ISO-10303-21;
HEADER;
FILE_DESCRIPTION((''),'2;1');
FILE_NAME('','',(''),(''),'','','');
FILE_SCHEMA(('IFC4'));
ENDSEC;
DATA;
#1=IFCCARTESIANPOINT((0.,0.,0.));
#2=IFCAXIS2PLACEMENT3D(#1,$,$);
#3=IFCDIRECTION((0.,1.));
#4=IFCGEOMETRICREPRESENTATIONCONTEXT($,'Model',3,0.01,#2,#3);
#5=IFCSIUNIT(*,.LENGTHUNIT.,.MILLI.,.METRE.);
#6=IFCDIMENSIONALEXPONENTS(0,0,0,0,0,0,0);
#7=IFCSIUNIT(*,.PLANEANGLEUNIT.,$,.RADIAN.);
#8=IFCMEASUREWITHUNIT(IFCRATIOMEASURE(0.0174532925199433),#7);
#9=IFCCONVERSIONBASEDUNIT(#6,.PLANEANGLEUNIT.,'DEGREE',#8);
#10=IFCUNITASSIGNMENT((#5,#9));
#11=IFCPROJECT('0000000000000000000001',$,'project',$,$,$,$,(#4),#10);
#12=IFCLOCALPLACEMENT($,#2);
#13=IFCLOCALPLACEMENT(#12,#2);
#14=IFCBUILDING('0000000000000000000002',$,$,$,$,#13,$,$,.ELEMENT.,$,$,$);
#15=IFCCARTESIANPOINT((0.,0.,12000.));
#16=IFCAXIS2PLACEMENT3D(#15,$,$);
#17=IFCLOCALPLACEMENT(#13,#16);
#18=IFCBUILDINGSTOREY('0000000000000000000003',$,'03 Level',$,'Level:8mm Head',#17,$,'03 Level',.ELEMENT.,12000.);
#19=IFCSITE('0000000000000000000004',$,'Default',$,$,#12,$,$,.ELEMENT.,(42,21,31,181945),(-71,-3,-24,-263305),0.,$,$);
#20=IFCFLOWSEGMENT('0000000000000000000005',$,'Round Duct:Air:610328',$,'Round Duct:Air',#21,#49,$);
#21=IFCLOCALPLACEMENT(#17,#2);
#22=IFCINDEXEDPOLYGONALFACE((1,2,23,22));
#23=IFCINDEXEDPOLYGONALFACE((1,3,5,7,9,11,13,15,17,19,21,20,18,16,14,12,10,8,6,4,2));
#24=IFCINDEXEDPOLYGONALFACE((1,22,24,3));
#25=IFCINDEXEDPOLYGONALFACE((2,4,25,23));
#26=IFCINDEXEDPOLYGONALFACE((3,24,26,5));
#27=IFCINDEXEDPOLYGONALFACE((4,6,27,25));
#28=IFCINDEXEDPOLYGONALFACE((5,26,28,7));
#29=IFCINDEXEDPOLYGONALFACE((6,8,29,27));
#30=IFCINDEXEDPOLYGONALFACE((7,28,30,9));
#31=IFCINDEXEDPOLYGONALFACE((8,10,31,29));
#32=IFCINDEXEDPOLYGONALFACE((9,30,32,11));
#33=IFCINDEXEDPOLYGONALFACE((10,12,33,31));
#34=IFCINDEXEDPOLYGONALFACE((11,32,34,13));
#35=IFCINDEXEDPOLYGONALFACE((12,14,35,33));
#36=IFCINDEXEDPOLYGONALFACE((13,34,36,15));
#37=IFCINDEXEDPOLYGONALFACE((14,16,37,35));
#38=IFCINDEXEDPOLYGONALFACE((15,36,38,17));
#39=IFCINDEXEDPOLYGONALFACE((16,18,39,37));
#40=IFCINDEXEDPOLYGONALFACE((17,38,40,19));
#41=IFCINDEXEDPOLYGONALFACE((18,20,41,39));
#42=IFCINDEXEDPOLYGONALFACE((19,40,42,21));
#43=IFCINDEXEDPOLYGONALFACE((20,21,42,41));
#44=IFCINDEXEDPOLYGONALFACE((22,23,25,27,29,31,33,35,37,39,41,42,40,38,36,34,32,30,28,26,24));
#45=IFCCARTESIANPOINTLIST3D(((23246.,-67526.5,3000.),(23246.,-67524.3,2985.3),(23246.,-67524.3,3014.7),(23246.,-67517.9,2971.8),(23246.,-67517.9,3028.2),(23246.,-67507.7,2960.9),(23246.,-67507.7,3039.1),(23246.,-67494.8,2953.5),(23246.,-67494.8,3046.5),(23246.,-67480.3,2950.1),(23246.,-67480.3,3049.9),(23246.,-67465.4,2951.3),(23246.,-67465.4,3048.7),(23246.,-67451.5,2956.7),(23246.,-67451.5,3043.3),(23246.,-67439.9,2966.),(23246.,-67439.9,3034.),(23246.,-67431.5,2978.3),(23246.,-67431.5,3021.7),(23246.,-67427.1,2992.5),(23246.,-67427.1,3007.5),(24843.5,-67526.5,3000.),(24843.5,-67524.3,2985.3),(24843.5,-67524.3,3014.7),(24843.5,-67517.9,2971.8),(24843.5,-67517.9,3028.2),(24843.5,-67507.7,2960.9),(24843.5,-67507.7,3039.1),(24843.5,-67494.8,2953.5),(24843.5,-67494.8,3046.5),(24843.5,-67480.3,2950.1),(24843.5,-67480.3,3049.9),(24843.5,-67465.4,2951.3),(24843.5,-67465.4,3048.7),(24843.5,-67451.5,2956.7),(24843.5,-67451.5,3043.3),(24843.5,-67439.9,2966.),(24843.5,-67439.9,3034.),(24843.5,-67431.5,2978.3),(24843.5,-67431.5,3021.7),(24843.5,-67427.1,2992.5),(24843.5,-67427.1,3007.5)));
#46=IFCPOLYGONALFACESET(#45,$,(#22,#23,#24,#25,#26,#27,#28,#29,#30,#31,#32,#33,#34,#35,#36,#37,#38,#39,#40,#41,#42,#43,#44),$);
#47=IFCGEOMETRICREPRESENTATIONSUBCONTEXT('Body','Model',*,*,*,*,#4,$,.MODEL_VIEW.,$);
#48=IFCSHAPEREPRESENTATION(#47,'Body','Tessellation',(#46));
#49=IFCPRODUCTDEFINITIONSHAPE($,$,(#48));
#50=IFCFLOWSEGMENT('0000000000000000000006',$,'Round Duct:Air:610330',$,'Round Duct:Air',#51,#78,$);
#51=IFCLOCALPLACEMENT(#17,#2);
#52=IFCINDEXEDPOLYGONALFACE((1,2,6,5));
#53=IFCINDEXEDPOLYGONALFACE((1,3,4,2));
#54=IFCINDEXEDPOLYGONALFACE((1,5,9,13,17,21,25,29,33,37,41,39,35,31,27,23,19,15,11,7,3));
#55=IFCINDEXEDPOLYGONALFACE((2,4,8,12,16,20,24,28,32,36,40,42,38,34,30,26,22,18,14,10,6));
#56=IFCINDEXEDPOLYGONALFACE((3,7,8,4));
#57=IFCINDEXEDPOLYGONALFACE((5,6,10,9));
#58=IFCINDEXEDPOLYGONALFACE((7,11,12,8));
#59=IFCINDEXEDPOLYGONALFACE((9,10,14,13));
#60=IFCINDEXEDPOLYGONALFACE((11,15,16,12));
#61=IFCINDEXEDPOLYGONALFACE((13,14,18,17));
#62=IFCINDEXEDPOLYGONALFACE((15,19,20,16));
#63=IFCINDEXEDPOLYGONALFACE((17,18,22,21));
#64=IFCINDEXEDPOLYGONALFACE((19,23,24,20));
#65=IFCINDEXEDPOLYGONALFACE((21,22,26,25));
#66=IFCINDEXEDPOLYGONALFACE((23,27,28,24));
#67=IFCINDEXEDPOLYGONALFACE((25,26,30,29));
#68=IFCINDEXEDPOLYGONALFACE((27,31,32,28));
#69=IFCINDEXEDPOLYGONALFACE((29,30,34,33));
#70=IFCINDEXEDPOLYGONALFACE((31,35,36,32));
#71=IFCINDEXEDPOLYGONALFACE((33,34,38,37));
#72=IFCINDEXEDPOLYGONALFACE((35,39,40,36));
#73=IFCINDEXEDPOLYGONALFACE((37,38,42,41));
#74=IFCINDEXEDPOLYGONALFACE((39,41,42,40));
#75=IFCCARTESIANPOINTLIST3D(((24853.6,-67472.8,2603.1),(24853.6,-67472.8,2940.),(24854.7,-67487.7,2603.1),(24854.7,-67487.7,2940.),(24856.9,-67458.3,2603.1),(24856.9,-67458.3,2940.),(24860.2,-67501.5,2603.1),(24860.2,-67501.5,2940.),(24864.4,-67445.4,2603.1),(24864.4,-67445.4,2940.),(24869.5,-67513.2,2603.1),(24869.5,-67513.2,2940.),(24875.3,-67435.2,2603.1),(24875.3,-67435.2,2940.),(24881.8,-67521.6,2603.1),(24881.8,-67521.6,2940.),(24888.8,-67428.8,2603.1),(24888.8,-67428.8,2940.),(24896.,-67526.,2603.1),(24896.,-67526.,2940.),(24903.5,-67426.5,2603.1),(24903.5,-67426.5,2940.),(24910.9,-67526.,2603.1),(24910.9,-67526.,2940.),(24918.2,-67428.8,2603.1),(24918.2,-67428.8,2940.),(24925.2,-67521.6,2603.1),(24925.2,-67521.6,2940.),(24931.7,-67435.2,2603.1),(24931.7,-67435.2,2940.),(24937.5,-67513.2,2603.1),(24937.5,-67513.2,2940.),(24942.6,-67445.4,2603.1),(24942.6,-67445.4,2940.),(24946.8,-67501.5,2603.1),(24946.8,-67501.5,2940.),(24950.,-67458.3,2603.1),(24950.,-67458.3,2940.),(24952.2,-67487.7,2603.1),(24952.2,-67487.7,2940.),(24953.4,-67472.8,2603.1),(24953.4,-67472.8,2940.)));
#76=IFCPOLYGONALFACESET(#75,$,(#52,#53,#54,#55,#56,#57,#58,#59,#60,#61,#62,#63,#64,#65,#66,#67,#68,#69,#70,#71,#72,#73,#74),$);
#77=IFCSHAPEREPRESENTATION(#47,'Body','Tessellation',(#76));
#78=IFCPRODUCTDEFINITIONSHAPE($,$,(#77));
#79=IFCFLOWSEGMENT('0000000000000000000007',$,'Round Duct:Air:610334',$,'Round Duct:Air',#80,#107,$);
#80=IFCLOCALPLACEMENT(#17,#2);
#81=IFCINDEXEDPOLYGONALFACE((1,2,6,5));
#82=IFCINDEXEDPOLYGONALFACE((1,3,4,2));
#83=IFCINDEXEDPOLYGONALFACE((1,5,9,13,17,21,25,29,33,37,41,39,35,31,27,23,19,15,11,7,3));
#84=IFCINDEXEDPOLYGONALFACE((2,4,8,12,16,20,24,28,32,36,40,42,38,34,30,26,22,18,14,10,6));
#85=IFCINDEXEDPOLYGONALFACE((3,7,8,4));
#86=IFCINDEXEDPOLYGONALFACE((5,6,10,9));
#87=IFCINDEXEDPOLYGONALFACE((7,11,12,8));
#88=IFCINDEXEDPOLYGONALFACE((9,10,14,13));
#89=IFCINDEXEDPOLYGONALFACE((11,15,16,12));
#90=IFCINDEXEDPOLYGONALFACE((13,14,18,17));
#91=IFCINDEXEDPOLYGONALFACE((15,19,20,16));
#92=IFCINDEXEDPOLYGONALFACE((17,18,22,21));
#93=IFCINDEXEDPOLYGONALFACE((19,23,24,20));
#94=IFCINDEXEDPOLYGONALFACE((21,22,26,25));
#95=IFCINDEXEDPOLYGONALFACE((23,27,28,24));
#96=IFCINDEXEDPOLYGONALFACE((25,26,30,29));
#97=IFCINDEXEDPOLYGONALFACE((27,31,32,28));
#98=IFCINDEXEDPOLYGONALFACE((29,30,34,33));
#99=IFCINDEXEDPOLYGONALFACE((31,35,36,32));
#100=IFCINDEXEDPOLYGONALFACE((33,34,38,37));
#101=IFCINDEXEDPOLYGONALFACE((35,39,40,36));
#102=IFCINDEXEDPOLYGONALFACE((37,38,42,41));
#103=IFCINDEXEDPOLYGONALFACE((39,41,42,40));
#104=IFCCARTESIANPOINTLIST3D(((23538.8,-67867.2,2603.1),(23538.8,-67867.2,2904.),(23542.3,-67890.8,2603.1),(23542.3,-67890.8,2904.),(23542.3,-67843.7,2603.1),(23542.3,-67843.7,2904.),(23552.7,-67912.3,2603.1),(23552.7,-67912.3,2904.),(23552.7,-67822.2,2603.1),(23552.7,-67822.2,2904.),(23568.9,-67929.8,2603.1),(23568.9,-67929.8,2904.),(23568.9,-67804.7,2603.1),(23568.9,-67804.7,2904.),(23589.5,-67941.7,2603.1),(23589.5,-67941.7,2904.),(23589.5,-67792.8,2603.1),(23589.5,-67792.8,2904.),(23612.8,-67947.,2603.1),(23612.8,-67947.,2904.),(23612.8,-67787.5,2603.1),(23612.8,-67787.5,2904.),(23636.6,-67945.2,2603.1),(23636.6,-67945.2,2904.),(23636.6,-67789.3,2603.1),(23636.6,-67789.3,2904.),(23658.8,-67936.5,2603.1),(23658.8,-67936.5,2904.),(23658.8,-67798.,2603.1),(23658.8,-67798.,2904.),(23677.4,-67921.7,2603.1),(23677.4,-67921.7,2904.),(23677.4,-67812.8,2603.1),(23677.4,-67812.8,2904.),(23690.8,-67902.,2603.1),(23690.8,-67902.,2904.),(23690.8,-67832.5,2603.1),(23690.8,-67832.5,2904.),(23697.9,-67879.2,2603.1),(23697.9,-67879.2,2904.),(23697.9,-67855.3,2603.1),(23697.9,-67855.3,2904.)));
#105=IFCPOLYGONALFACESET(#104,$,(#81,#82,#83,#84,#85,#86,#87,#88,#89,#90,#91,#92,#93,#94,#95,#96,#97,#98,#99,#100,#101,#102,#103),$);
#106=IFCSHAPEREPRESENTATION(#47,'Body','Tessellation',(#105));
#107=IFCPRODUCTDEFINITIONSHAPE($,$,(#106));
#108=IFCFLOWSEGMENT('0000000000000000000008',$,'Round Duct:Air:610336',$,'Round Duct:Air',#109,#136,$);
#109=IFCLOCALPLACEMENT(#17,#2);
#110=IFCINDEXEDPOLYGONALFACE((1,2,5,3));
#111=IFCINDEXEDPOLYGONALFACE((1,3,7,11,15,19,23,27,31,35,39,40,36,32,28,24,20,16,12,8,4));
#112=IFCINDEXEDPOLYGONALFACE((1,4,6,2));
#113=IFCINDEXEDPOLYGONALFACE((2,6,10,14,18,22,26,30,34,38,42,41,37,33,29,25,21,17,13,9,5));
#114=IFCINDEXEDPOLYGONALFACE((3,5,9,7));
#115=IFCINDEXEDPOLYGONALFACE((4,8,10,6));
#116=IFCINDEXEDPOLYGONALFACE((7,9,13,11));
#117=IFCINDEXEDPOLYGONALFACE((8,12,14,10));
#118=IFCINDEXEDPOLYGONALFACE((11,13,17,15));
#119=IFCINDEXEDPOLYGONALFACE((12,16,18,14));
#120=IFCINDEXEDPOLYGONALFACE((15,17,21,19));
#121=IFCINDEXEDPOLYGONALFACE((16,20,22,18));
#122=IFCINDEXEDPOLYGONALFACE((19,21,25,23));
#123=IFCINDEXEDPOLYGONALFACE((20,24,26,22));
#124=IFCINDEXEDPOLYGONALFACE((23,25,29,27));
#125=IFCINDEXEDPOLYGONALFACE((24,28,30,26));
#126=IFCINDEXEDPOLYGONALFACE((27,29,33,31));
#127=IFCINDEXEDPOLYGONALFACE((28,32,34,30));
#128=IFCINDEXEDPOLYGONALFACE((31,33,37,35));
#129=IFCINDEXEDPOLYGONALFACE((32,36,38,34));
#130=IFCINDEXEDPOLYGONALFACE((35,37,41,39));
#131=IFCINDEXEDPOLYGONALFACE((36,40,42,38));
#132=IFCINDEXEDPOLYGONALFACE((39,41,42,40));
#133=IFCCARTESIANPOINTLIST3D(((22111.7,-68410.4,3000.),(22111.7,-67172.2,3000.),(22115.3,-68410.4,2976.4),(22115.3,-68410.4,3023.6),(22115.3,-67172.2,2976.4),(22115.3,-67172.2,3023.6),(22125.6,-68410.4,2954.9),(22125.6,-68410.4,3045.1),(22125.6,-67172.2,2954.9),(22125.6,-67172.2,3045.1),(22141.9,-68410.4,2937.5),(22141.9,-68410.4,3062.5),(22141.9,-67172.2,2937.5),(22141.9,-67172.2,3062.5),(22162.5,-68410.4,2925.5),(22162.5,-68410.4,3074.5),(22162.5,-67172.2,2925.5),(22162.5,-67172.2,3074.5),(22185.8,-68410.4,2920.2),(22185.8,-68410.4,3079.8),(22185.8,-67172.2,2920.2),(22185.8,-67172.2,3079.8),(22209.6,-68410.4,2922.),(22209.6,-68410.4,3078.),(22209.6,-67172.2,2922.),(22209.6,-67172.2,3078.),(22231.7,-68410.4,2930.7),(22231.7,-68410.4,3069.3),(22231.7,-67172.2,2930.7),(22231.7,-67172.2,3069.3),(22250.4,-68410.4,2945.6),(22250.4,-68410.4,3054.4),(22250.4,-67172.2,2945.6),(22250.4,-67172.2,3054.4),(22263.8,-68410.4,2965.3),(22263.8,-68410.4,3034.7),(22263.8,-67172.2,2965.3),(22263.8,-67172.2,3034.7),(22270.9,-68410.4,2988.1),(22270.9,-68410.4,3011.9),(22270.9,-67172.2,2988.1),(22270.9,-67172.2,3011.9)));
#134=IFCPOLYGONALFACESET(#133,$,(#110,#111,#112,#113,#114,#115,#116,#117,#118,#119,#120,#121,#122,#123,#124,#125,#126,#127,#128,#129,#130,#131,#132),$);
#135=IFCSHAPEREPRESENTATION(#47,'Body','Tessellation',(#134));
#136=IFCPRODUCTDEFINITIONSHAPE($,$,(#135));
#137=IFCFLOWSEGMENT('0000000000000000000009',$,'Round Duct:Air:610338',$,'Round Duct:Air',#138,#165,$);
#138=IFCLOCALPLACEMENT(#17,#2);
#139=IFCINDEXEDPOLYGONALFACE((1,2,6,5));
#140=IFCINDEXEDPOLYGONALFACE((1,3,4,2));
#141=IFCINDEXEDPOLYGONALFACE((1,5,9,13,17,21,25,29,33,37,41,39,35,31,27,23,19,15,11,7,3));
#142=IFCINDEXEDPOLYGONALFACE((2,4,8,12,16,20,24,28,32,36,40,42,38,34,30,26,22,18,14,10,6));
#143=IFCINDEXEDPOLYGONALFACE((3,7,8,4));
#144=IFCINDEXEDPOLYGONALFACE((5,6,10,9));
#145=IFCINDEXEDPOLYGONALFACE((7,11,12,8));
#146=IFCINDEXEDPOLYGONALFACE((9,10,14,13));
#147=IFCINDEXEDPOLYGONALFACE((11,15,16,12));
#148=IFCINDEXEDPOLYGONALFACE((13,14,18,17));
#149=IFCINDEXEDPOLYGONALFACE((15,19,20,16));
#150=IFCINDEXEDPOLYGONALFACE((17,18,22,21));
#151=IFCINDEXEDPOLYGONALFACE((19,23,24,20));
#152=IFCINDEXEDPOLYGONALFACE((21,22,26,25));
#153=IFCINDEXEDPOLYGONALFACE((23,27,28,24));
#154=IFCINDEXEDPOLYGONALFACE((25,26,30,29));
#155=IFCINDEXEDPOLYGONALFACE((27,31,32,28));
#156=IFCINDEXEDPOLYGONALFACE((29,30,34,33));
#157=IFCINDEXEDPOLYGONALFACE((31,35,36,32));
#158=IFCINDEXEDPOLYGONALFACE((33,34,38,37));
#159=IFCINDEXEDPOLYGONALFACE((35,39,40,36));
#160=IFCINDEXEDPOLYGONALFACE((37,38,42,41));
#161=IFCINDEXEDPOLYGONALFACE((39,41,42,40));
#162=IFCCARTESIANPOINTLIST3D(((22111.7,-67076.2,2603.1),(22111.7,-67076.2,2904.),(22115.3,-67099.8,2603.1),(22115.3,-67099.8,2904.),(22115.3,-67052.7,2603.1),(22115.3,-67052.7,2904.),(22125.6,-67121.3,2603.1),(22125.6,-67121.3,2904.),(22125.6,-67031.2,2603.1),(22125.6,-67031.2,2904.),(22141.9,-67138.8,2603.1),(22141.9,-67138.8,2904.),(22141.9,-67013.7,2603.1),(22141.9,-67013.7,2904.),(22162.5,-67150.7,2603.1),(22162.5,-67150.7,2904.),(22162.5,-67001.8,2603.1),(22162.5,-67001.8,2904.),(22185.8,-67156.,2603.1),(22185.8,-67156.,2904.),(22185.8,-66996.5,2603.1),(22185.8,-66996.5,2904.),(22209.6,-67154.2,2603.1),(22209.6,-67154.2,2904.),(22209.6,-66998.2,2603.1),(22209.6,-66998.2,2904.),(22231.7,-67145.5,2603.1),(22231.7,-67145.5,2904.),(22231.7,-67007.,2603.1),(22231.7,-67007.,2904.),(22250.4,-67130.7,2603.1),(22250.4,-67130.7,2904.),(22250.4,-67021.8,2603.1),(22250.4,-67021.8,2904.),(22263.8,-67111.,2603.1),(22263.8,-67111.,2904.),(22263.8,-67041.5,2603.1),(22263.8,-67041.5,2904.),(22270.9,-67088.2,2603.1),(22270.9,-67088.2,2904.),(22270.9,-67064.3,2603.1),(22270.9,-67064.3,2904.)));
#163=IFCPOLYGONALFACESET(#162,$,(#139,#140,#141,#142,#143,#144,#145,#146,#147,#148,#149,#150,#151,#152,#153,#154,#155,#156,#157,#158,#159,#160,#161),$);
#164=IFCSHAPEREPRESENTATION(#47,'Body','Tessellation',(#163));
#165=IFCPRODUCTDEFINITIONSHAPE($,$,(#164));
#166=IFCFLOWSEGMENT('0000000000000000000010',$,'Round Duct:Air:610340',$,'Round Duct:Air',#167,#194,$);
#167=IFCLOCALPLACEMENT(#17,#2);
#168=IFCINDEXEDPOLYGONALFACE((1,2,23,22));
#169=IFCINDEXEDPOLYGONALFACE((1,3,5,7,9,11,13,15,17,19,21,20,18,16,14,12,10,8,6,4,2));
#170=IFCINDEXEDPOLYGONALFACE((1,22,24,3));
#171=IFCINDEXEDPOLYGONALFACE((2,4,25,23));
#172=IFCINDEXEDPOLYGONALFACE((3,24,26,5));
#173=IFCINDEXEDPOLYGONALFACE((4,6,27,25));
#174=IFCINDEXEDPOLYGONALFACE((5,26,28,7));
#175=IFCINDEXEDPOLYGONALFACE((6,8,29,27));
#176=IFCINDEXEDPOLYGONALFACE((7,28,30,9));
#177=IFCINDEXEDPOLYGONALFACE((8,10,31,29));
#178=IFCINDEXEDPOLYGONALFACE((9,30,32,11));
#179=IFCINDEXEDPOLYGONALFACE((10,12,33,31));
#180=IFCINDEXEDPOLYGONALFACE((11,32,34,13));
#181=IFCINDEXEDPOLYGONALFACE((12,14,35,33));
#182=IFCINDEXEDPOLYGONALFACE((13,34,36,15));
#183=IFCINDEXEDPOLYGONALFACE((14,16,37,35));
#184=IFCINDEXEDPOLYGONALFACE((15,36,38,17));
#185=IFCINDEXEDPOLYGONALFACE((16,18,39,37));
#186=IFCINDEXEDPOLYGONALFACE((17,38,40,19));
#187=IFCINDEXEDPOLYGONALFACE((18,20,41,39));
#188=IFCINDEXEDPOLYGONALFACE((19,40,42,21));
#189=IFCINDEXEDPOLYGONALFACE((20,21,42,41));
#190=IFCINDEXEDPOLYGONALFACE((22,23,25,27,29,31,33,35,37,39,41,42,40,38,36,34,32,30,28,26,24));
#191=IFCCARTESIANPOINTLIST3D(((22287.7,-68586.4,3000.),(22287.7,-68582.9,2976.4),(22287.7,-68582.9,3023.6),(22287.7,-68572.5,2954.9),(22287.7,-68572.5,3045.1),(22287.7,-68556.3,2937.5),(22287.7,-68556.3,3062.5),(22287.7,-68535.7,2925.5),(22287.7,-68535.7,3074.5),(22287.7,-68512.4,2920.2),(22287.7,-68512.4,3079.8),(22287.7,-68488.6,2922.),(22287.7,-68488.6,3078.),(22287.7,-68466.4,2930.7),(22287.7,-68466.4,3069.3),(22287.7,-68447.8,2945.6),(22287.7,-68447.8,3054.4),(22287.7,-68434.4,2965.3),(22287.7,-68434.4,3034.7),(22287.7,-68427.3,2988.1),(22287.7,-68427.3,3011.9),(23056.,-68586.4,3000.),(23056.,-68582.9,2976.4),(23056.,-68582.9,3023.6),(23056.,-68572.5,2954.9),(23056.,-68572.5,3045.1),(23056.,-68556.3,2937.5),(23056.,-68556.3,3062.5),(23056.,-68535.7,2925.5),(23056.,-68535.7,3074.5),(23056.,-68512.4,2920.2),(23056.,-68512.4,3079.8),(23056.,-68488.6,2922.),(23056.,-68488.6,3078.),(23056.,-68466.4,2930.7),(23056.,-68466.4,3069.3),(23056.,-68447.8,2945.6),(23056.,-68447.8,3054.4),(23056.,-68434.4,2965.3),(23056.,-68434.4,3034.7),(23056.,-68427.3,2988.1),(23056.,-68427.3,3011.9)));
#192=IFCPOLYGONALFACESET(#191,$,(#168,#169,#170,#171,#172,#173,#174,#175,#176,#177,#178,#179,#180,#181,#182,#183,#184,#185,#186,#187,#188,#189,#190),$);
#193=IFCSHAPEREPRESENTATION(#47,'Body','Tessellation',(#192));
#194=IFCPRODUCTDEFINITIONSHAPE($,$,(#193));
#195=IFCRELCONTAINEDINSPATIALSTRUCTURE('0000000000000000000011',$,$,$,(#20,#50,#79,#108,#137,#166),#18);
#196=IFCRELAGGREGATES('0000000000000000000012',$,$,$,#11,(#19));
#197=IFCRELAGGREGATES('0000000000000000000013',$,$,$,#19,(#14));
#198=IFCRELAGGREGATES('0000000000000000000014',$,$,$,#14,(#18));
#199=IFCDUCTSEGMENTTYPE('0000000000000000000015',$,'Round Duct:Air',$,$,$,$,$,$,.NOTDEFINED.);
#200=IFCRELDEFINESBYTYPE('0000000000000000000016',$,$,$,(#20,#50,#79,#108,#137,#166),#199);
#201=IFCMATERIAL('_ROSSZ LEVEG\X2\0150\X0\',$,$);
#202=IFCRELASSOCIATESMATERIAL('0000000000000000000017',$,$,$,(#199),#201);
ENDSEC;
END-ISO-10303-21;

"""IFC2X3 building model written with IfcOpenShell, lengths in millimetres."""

from ifc_helpers import new_model, entity, si_unit, converted_unit, direction, frame, frame_2d, origin, origin_2d_with_axis, place, context, subcontext, project, spatial, circle, extrude, material, type_object, element, save


model = new_model("IFC2X3")

# Units and contexts
model_context = context("Model", 3, precision=0.01, world=origin(), true_north=direction((0.0, 1.0)))
body_context = subcontext(model_context, "Body", "Model", "MODEL_VIEW")
ifc_project = project(units=[si_unit("LENGTHUNIT", "METRE", prefix="MILLI"), converted_unit("PLANEANGLEUNIT", "DEGREE", entity("IfcRatioMeasure", 0.0174532925199433), si_unit("PLANEANGLEUNIT", "RADIAN"), dimensions=[0, 0, 0, 0, 0, 0, 0])], contexts=[model_context])

# Site, building, storey
site_placement = place(None, origin())
site = spatial("IfcSite", under=ifc_project, at=site_placement, Name="Default", CompositionType="ELEMENT", RefLatitude=(42, 21, 31, 181945), RefLongitude=(-71, -3, -24, -263305), RefElevation=0.0)
building_placement = place(site_placement, origin())
building = spatial("IfcBuilding", under=site, at=building_placement, CompositionType="ELEMENT")
storey_placement = place(building_placement, frame((0.0, 0.0, 12000.0)))
storey = spatial("IfcBuildingStorey", under=building, at=storey_placement, Name="03 Level", ObjectType="Level:8mm Head", LongName="03 Level", CompositionType="ELEMENT", Elevation=12000.0)

# Flow segments
ifc_material = material(Name="_ROSSZ LEVEGŐ")
duct_segment_type_1 = type_object("IfcDuctSegmentType", Name="Round Duct:Air", PredefinedType="NOTDEFINED", material=ifc_material)
flow_segment_1_placement = place(storey_placement, origin())
element("IfcFlowSegment", 1, at=flow_segment_1_placement, inside=storey, type_object=duct_segment_type_1, Name="Round Duct:Air:610328", ObjectType="Round Duct:Air", context=body_context, shape_type="SweptSolid", body=[
    extrude(circle(Radius=50.0, at=origin_2d_with_axis()), frame((23246.0, -67476.5, 3000.0), z_axis=(1.0, 0.0, 0.0), x_axis=(0.0, -1.0, 0.0)), (0.0, 0.0, 1.0), 1597.5),
])
flow_segment_2_placement = place(storey_placement, origin())
element("IfcFlowSegment", 2, at=flow_segment_2_placement, inside=storey, type_object=duct_segment_type_1, Name="Round Duct:Air:610330", ObjectType="Round Duct:Air", context=body_context, shape_type="SweptSolid", body=[
    extrude(circle(Radius=50.0, at=origin_2d_with_axis()), frame((24903.5, -67476.5, 2603.1), z_axis=(0.0, 0.0, 1.0), x_axis=(0.0, 1.0, 0.0)), (0.0, 0.0, 1.0), 336.9),
])
flow_segment_3_placement = place(storey_placement, origin())
element("IfcFlowSegment", 3, at=flow_segment_3_placement, inside=storey, type_object=duct_segment_type_1, Name="Round Duct:Air:610334", ObjectType="Round Duct:Air", context=body_context, shape_type="SweptSolid", body=[
    extrude(circle(Radius=80.0, at=origin_2d_with_axis()), frame((23618.8, -67867.2, 2603.1), z_axis=(0.0, 0.0, 1.0), x_axis=(-1.0, 0.0, 0.0)), (0.0, 0.0, 1.0), 300.9),
])
flow_segment_4_placement = place(storey_placement, origin())
element("IfcFlowSegment", 4, at=flow_segment_4_placement, inside=storey, type_object=duct_segment_type_1, Name="Round Duct:Air:610336", ObjectType="Round Duct:Air", context=body_context, shape_type="SweptSolid", body=[
    extrude(circle(Radius=80.0, at=frame_2d((0.0, 0.0), x_axis=(1.0, 0.0))), frame((22191.7, -68410.4, 3000.0), z_axis=(0.0, 1.0, 0.0), x_axis=(-1.0, 0.0, 0.0)), (0.0, 0.0, 1.0), 1238.2),
])
flow_segment_5_placement = place(storey_placement, origin())
element("IfcFlowSegment", 5, at=flow_segment_5_placement, inside=storey, type_object=duct_segment_type_1, Name="Round Duct:Air:610338", ObjectType="Round Duct:Air", context=body_context, shape_type="SweptSolid", body=[
    extrude(circle(Radius=80.0, at=origin_2d_with_axis()), frame((22191.7, -67076.2, 2603.1), z_axis=(0.0, 0.0, 1.0), x_axis=(-1.0, 0.0, 0.0)), (0.0, 0.0, 1.0), 300.9),
])
flow_segment_6_placement = place(storey_placement, origin())
element("IfcFlowSegment", 6, at=flow_segment_6_placement, inside=storey, type_object=duct_segment_type_1, Name="Round Duct:Air:610340", ObjectType="Round Duct:Air", context=body_context, shape_type="SweptSolid", body=[
    extrude(circle(Radius=80.0, at=origin_2d_with_axis()), frame((22287.7, -68506.4, 3000.0), z_axis=(1.0, 0.0, 0.0), x_axis=(0.0, -1.0, 0.0)), (0.0, 0.0, 1.0), 768.2),
])

save(model, "model.ifc")
